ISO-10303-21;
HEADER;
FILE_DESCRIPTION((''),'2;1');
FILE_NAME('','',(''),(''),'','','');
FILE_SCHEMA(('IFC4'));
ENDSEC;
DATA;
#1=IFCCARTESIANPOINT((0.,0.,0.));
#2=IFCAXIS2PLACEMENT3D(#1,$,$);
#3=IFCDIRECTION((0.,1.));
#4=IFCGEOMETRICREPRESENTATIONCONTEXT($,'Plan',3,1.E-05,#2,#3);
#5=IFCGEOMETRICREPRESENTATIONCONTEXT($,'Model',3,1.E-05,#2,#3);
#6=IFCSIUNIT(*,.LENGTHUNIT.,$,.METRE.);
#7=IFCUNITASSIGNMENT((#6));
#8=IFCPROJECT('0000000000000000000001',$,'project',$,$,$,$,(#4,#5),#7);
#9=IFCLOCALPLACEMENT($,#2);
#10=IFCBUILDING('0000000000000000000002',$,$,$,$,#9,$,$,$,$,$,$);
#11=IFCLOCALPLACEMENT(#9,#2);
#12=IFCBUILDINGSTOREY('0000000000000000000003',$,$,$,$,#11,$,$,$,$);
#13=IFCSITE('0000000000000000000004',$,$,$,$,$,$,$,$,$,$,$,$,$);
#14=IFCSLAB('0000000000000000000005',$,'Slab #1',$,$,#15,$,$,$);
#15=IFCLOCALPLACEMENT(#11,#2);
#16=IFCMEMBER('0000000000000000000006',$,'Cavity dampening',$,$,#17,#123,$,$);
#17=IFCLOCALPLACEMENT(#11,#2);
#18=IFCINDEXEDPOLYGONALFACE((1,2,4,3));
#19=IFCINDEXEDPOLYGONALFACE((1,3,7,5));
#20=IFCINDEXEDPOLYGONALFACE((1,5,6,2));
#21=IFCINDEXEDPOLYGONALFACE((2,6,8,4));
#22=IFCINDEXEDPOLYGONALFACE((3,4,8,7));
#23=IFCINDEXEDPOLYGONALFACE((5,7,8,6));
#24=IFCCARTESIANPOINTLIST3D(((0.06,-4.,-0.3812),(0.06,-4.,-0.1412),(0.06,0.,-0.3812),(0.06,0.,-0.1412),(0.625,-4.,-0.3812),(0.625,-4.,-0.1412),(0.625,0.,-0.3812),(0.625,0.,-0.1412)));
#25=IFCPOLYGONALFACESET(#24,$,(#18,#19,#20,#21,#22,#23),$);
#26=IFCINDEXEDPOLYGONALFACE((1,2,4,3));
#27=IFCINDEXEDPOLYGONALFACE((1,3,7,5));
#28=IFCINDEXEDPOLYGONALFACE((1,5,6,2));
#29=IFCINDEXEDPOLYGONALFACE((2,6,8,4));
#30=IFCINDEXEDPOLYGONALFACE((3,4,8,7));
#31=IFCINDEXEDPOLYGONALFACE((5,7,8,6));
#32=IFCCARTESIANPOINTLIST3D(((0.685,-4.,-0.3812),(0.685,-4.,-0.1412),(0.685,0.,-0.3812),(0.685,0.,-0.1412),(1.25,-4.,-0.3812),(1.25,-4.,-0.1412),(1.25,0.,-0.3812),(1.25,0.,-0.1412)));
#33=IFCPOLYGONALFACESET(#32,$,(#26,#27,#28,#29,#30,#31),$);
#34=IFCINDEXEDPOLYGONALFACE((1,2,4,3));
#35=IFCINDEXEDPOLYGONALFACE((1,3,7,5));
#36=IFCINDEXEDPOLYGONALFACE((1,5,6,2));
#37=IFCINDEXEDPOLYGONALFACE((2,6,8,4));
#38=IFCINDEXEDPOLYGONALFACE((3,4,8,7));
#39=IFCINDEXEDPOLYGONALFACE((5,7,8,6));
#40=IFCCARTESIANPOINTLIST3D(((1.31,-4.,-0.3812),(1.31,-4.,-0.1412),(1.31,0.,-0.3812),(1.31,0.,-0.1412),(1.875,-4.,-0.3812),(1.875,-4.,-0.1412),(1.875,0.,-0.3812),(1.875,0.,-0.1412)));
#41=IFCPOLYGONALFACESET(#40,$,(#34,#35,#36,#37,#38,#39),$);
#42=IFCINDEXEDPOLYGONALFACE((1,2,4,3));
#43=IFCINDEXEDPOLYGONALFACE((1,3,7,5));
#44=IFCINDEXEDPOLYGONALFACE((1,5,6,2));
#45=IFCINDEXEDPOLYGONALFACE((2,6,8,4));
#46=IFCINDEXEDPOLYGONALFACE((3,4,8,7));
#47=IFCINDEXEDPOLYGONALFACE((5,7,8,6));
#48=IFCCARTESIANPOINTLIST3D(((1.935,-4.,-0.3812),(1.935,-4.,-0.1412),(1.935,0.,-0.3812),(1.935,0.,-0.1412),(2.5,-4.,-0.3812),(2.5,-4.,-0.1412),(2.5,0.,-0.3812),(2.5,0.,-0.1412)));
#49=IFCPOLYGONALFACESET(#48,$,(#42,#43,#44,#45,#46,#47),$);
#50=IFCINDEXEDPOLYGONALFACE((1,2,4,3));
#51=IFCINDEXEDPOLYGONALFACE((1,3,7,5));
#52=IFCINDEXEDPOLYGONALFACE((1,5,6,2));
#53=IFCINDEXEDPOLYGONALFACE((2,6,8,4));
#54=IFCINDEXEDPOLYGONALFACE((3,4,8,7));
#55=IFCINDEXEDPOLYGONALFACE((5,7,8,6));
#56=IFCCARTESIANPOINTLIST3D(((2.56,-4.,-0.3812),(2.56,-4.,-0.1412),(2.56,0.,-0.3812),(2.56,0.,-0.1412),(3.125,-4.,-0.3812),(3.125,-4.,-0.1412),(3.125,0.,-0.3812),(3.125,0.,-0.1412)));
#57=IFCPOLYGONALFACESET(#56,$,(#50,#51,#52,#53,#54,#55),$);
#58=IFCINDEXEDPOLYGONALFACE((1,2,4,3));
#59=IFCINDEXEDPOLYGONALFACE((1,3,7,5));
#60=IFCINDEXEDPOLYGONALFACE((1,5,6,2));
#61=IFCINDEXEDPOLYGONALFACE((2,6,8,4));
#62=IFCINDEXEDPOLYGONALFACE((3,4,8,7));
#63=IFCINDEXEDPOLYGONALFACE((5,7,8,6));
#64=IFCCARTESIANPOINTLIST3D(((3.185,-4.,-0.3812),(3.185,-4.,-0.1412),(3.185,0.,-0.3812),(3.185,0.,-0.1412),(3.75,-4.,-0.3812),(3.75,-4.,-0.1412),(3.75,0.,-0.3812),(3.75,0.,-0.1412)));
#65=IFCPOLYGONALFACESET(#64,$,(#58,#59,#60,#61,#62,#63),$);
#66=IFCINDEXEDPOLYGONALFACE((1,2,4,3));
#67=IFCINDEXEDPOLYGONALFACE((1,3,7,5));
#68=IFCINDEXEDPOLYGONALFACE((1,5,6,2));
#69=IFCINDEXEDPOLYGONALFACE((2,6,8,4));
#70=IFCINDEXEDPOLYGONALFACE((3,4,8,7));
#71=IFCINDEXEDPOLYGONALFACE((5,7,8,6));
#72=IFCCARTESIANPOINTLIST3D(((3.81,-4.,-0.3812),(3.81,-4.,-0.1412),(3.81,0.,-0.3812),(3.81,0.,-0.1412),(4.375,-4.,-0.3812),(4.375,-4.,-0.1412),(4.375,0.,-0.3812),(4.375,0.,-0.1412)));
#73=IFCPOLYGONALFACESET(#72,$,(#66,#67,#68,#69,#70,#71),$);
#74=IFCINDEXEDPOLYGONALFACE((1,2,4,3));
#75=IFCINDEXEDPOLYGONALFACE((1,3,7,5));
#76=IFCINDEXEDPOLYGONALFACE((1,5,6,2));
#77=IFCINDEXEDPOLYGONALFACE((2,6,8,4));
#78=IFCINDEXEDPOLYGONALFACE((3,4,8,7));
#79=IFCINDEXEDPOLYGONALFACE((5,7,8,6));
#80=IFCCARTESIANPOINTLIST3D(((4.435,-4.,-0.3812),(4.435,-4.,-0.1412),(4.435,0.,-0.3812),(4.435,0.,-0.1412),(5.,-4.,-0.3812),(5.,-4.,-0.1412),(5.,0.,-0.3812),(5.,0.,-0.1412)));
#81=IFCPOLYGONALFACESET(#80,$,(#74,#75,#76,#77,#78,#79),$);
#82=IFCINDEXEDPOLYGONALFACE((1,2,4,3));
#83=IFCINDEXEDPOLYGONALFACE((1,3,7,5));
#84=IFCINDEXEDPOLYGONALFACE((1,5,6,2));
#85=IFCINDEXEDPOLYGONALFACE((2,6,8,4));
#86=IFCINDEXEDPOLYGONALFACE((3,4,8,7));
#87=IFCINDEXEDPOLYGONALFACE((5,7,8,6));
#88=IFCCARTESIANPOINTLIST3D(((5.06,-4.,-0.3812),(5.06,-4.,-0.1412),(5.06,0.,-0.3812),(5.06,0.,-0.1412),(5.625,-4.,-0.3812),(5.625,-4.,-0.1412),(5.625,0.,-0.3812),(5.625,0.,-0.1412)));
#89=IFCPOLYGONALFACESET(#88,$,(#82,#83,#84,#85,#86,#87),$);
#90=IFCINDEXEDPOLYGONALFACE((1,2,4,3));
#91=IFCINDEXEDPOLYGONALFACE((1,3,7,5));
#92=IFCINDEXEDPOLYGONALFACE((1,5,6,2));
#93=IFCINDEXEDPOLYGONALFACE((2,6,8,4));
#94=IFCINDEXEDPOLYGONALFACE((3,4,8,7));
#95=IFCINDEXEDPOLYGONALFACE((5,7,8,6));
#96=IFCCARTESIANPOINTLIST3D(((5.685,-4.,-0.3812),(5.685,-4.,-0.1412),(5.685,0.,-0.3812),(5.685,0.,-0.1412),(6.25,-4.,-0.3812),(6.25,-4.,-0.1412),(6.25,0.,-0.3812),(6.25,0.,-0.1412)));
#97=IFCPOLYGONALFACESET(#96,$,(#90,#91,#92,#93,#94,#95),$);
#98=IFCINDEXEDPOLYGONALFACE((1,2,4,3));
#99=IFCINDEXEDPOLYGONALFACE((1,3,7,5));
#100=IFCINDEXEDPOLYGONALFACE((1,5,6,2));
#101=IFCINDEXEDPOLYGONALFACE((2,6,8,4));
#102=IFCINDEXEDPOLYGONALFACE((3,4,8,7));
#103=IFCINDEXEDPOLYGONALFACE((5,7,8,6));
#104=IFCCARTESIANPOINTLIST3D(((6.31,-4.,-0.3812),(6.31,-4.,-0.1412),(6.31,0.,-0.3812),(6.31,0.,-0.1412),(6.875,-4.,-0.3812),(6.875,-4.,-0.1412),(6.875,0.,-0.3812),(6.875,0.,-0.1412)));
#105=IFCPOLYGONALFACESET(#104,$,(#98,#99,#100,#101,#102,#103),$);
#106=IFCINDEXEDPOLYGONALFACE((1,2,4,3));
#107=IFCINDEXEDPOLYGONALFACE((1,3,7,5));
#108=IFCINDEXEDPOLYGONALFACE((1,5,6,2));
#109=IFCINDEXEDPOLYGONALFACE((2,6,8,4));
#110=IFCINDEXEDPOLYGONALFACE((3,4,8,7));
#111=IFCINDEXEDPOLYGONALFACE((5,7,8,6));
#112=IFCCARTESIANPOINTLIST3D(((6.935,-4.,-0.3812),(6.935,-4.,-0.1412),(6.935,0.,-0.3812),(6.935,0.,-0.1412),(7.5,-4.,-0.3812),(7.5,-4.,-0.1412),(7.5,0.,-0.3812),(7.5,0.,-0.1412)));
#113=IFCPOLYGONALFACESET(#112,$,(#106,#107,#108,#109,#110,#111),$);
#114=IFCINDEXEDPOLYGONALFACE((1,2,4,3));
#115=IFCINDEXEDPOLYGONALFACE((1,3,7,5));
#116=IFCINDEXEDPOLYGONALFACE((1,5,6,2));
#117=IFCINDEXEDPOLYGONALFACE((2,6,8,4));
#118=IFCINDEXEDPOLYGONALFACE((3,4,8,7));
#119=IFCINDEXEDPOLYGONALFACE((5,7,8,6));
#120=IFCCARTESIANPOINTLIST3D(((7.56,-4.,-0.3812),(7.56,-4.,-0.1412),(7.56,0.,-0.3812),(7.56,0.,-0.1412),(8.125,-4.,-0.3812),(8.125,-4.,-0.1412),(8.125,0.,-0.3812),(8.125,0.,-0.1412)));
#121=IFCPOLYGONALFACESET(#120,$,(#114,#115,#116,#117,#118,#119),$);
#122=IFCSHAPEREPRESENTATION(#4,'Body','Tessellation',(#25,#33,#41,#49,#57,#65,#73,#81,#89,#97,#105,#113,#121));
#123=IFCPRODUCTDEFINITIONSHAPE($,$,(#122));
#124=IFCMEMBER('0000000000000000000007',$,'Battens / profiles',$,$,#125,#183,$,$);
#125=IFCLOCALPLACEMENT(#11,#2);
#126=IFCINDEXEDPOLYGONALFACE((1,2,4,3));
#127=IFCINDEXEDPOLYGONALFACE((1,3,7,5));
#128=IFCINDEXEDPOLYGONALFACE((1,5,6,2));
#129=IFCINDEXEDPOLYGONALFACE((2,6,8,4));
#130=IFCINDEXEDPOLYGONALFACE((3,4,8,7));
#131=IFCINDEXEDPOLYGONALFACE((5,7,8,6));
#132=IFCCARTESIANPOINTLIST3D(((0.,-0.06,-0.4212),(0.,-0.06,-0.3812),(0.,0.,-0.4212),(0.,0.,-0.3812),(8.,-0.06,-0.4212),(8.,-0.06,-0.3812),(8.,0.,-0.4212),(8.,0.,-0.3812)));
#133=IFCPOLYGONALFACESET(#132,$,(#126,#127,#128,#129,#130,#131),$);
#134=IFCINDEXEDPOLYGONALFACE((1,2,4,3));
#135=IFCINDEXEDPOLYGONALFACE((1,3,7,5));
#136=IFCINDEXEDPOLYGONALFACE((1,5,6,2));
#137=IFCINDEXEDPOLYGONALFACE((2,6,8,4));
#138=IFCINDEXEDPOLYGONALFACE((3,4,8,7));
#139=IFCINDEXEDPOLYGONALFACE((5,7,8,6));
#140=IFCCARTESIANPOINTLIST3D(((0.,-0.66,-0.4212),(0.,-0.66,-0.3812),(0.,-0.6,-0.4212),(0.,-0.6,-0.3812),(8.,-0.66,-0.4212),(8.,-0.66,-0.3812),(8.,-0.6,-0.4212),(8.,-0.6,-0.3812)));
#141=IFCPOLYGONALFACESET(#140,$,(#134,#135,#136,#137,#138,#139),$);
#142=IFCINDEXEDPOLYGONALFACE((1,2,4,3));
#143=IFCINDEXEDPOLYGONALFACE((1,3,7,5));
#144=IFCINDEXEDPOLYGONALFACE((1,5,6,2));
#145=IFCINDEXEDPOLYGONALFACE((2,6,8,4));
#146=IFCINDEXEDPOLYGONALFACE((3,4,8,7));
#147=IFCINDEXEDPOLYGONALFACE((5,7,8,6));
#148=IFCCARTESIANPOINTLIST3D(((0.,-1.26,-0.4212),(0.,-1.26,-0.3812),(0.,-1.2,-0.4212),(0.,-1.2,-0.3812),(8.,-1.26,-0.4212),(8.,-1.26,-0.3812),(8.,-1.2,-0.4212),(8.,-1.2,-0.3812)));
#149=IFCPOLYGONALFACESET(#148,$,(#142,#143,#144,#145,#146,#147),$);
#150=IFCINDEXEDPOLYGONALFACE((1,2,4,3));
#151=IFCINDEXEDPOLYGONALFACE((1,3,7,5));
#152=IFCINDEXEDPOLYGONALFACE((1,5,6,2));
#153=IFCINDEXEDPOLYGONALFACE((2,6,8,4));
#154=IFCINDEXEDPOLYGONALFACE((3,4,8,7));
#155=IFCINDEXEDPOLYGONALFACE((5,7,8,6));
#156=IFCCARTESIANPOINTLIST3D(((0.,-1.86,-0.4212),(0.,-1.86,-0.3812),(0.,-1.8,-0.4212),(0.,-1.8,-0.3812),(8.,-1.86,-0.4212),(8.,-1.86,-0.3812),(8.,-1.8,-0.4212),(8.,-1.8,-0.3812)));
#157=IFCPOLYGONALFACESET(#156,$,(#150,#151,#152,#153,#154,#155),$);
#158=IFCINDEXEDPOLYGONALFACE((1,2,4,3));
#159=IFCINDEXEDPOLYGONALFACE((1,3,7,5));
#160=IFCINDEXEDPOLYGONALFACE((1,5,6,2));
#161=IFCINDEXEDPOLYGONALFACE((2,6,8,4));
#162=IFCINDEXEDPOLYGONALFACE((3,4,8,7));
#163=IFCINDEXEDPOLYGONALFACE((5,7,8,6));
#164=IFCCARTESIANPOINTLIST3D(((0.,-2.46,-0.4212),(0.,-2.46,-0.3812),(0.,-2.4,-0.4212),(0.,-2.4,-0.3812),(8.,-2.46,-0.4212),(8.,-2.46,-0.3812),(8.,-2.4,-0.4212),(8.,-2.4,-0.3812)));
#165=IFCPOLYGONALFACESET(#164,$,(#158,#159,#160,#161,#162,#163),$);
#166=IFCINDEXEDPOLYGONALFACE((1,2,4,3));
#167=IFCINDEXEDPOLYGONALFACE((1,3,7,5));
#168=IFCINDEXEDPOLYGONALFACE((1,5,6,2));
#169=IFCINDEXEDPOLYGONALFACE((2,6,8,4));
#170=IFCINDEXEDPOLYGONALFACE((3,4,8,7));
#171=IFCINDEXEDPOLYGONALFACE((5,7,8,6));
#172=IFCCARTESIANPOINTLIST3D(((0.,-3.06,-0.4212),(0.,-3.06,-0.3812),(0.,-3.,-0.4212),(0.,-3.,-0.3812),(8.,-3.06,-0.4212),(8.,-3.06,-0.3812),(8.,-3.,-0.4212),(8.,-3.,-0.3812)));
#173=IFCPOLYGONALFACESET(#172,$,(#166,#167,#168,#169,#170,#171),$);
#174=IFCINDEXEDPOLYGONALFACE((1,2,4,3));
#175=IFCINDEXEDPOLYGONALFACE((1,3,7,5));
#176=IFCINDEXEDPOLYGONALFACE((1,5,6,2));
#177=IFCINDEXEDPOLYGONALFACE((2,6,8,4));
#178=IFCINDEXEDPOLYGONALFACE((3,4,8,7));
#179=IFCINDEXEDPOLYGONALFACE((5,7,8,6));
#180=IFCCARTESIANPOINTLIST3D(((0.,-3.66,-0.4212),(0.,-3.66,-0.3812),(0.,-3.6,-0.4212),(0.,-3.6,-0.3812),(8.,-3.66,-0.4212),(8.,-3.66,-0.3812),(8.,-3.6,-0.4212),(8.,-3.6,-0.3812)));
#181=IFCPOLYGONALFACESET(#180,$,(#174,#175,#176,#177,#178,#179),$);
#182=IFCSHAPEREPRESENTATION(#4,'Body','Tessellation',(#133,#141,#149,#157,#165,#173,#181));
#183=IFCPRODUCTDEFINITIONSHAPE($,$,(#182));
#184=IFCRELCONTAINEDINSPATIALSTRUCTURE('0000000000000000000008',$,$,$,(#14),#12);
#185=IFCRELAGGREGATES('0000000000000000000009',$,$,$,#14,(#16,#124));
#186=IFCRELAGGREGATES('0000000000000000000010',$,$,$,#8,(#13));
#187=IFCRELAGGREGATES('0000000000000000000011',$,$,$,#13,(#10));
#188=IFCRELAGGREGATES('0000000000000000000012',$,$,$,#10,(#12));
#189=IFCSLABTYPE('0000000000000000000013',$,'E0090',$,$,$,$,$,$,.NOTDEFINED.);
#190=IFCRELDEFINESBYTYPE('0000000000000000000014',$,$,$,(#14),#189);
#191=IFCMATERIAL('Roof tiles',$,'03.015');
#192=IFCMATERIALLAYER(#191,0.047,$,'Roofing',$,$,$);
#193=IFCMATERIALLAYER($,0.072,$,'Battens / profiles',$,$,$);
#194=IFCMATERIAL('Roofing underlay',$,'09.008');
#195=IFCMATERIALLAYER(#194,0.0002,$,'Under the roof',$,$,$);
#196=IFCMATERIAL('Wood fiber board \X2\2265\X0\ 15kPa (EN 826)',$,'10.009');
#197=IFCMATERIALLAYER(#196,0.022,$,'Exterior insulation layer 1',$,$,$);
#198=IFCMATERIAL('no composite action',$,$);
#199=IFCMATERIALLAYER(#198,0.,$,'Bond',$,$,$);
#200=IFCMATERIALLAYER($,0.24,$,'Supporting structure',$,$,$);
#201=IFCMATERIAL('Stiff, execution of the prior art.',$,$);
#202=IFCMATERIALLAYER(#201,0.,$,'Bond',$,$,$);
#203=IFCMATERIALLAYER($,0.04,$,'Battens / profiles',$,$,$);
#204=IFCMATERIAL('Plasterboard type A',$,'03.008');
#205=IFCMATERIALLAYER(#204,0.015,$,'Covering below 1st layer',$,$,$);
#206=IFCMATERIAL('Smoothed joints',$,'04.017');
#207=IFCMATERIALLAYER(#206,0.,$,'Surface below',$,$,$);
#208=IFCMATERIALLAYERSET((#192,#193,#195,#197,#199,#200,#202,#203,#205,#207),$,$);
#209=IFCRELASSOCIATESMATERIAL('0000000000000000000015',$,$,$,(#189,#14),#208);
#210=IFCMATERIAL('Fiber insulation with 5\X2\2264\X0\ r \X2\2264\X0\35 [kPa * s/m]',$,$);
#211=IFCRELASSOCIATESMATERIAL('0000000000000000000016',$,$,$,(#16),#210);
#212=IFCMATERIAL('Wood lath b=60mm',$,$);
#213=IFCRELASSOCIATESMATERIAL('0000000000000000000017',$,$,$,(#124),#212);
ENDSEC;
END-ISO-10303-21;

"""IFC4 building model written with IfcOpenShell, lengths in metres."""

from ifc_helpers import new_model, si_unit, direction, frame, frame_2d, origin, place, context, project, spatial, rectangle, extrude, material, layer, layer_set, type_object, element, aggregate, save


model = new_model("IFC4")

# Units and contexts
plan_context = context("Plan", 3, precision=1e-05, world=origin(), true_north=direction((0.0, 1.0)))
model_context = context("Model", 3, precision=1e-05, world=origin(), true_north=direction((0.0, 1.0)))
ifc_project = project(units=[si_unit("LENGTHUNIT", "METRE")], contexts=[plan_context, model_context])

# Site, building, storey
site = spatial("IfcSite", under=ifc_project)
building_placement = place(None, origin())
building = spatial("IfcBuilding", under=site, at=building_placement)
storey_placement = place(building_placement, origin())
storey = spatial("IfcBuildingStorey", under=building, at=storey_placement)

# Slab, members
ifc_material_1 = material(Name="Roof tiles", Category="03.015")
ifc_layer_1 = layer(ifc_material_1, 0.047, Name="Roofing")
ifc_layer_2 = layer(None, 0.072, Name="Battens / profiles")
ifc_material_2 = material(Name="Roofing underlay", Category="09.008")
ifc_layer_3 = layer(ifc_material_2, 0.0002, Name="Under the roof")
ifc_material_3 = material(Name="Wood fiber board ≥ 15kPa (EN 826)", Category="10.009")
ifc_layer_4 = layer(ifc_material_3, 0.022, Name="Exterior insulation layer 1")
ifc_material_4 = material(Name="no composite action")
ifc_layer_5 = layer(ifc_material_4, 0.0, Name="Bond")
ifc_layer_6 = layer(None, 0.24, Name="Supporting structure")
ifc_material_5 = material(Name="Stiff, execution of the prior art.")
ifc_layer_7 = layer(ifc_material_5, 0.0, Name="Bond")
ifc_layer_8 = layer(None, 0.04, Name="Battens / profiles")
ifc_material_6 = material(Name="Plasterboard type A", Category="03.008")
ifc_layer_9 = layer(ifc_material_6, 0.015, Name="Covering below 1st layer")
ifc_material_7 = material(Name="Smoothed joints", Category="04.017")
ifc_layer_10 = layer(ifc_material_7, 0.0, Name="Surface below")
ifc_layer_set = layer_set([ifc_layer_1, ifc_layer_2, ifc_layer_3, ifc_layer_4, ifc_layer_5, ifc_layer_6, ifc_layer_7, ifc_layer_8, ifc_layer_9, ifc_layer_10])
slab_type = type_object("IfcSlabType", Name="E0090", PredefinedType="NOTDEFINED", material=ifc_layer_set)
slab_placement = place(None, frame((0.0, 0.0, 0.0), z_axis=(0.0, 0.0, -1.0), x_axis=(1.0, 0.0, 0.0)))
slab = element("IfcSlab", 1, at=slab_placement, inside=storey, type_object=slab_type, material=ifc_layer_set, Name="Slab #1")
ifc_material_8 = material(Name="Fiber insulation with 5≤ r ≤35 [kPa * s/m]")
member_1_placement = place(slab_placement, origin())
member_1 = element("IfcMember", 2, at=member_1_placement, material=ifc_material_8, Name="Cavity dampening", context=plan_context, shape_type="SweptSolid", body=[
    extrude(rectangle(XDim=0.565, YDim=0.24, at=frame_2d((0.2825, 0.12), x_axis=(1.0, 0.0))), frame((0.06, 4.0, 0.1412), z_axis=(0.0, -1.0, 0.0), x_axis=(1.0, 0.0, 0.0)), (0.0, 0.0, 1.0), 4.0),
    extrude(rectangle(XDim=0.565, YDim=0.24, at=frame_2d((0.2825, 0.12), x_axis=(1.0, 0.0))), frame((0.685, 4.0, 0.1412), z_axis=(0.0, -1.0, 0.0), x_axis=(1.0, 0.0, 0.0)), (0.0, 0.0, 1.0), 4.0),
    extrude(rectangle(XDim=0.565, YDim=0.24, at=frame_2d((0.2825, 0.12), x_axis=(1.0, 0.0))), frame((1.31, 4.0, 0.1412), z_axis=(0.0, -1.0, 0.0), x_axis=(1.0, 0.0, 0.0)), (0.0, 0.0, 1.0), 4.0),
    extrude(rectangle(XDim=0.565, YDim=0.24, at=frame_2d((0.2825, 0.12), x_axis=(1.0, 0.0))), frame((1.935, 4.0, 0.1412), z_axis=(0.0, -1.0, 0.0), x_axis=(1.0, 0.0, 0.0)), (0.0, 0.0, 1.0), 4.0),
    extrude(rectangle(XDim=0.565, YDim=0.24, at=frame_2d((0.2825, 0.12), x_axis=(1.0, 0.0))), frame((2.56, 4.0, 0.1412), z_axis=(0.0, -1.0, 0.0), x_axis=(1.0, 0.0, 0.0)), (0.0, 0.0, 1.0), 4.0),
    extrude(rectangle(XDim=0.565, YDim=0.24, at=frame_2d((0.2825, 0.12), x_axis=(1.0, 0.0))), frame((3.185, 4.0, 0.1412), z_axis=(0.0, -1.0, 0.0), x_axis=(1.0, 0.0, 0.0)), (0.0, 0.0, 1.0), 4.0),
    extrude(rectangle(XDim=0.565, YDim=0.24, at=frame_2d((0.2825, 0.12), x_axis=(1.0, 0.0))), frame((3.81, 4.0, 0.1412), z_axis=(0.0, -1.0, 0.0), x_axis=(1.0, 0.0, 0.0)), (0.0, 0.0, 1.0), 4.0),
    extrude(rectangle(XDim=0.565, YDim=0.24, at=frame_2d((0.2825, 0.12), x_axis=(1.0, 0.0))), frame((4.435, 4.0, 0.1412), z_axis=(0.0, -1.0, 0.0), x_axis=(1.0, 0.0, 0.0)), (0.0, 0.0, 1.0), 4.0),
    extrude(rectangle(XDim=0.565, YDim=0.24, at=frame_2d((0.2825, 0.12), x_axis=(1.0, 0.0))), frame((5.06, 4.0, 0.1412), z_axis=(0.0, -1.0, 0.0), x_axis=(1.0, 0.0, 0.0)), (0.0, 0.0, 1.0), 4.0),
    extrude(rectangle(XDim=0.565, YDim=0.24, at=frame_2d((0.2825, 0.12), x_axis=(1.0, 0.0))), frame((5.685, 4.0, 0.1412), z_axis=(0.0, -1.0, 0.0), x_axis=(1.0, 0.0, 0.0)), (0.0, 0.0, 1.0), 4.0),
    extrude(rectangle(XDim=0.565, YDim=0.24, at=frame_2d((0.2825, 0.12), x_axis=(1.0, 0.0))), frame((6.31, 4.0, 0.1412), z_axis=(0.0, -1.0, 0.0), x_axis=(1.0, 0.0, 0.0)), (0.0, 0.0, 1.0), 4.0),
    extrude(rectangle(XDim=0.565, YDim=0.24, at=frame_2d((0.2825, 0.12), x_axis=(1.0, 0.0))), frame((6.935, 4.0, 0.1412), z_axis=(0.0, -1.0, 0.0), x_axis=(1.0, 0.0, 0.0)), (0.0, 0.0, 1.0), 4.0),
    extrude(rectangle(XDim=0.565, YDim=0.24, at=frame_2d((0.2825, 0.12), x_axis=(1.0, 0.0))), frame((7.56, 4.0, 0.1412), z_axis=(0.0, -1.0, 0.0), x_axis=(1.0, 0.0, 0.0)), (0.0, 0.0, 1.0), 4.0),
])
ifc_material_9 = material(Name="Wood lath b=60mm")
member_2_placement = place(slab_placement, origin())
member_2 = element("IfcMember", 3, at=member_2_placement, material=ifc_material_9, Name="Battens / profiles", context=plan_context, shape_type="SweptSolid", body=[
    extrude(rectangle(XDim=0.06, YDim=0.04, at=frame_2d((0.03, 0.02), x_axis=(1.0, 0.0))), frame((0.0, 0.0, 0.3812), z_axis=(1.0, 0.0, 0.0), x_axis=(0.0, 1.0, 0.0)), (0.0, 0.0, 1.0), 8.0),
    extrude(rectangle(XDim=0.06, YDim=0.04, at=frame_2d((0.03, 0.02), x_axis=(1.0, 0.0))), frame((0.0, 0.6, 0.3812), z_axis=(1.0, 0.0, 0.0), x_axis=(0.0, 1.0, 0.0)), (0.0, 0.0, 1.0), 8.0),
    extrude(rectangle(XDim=0.06, YDim=0.04, at=frame_2d((0.03, 0.02), x_axis=(1.0, 0.0))), frame((0.0, 1.2, 0.3812), z_axis=(1.0, 0.0, 0.0), x_axis=(0.0, 1.0, 0.0)), (0.0, 0.0, 1.0), 8.0),
    extrude(rectangle(XDim=0.06, YDim=0.04, at=frame_2d((0.03, 0.02), x_axis=(1.0, 0.0))), frame((0.0, 1.8, 0.3812), z_axis=(1.0, 0.0, 0.0), x_axis=(0.0, 1.0, 0.0)), (0.0, 0.0, 1.0), 8.0),
    extrude(rectangle(XDim=0.06, YDim=0.04, at=frame_2d((0.03, 0.02), x_axis=(1.0, 0.0))), frame((0.0, 2.4, 0.3812), z_axis=(1.0, 0.0, 0.0), x_axis=(0.0, 1.0, 0.0)), (0.0, 0.0, 1.0), 8.0),
    extrude(rectangle(XDim=0.06, YDim=0.04, at=frame_2d((0.03, 0.02), x_axis=(1.0, 0.0))), frame((0.0, 3.0, 0.3812), z_axis=(1.0, 0.0, 0.0), x_axis=(0.0, 1.0, 0.0)), (0.0, 0.0, 1.0), 8.0),
    extrude(rectangle(XDim=0.06, YDim=0.04, at=frame_2d((0.03, 0.02), x_axis=(1.0, 0.0))), frame((0.0, 3.6, 0.3812), z_axis=(1.0, 0.0, 0.0), x_axis=(0.0, 1.0, 0.0)), (0.0, 0.0, 1.0), 8.0),
])
aggregate(slab, [member_1, member_2])

save(model, "model.ifc")
